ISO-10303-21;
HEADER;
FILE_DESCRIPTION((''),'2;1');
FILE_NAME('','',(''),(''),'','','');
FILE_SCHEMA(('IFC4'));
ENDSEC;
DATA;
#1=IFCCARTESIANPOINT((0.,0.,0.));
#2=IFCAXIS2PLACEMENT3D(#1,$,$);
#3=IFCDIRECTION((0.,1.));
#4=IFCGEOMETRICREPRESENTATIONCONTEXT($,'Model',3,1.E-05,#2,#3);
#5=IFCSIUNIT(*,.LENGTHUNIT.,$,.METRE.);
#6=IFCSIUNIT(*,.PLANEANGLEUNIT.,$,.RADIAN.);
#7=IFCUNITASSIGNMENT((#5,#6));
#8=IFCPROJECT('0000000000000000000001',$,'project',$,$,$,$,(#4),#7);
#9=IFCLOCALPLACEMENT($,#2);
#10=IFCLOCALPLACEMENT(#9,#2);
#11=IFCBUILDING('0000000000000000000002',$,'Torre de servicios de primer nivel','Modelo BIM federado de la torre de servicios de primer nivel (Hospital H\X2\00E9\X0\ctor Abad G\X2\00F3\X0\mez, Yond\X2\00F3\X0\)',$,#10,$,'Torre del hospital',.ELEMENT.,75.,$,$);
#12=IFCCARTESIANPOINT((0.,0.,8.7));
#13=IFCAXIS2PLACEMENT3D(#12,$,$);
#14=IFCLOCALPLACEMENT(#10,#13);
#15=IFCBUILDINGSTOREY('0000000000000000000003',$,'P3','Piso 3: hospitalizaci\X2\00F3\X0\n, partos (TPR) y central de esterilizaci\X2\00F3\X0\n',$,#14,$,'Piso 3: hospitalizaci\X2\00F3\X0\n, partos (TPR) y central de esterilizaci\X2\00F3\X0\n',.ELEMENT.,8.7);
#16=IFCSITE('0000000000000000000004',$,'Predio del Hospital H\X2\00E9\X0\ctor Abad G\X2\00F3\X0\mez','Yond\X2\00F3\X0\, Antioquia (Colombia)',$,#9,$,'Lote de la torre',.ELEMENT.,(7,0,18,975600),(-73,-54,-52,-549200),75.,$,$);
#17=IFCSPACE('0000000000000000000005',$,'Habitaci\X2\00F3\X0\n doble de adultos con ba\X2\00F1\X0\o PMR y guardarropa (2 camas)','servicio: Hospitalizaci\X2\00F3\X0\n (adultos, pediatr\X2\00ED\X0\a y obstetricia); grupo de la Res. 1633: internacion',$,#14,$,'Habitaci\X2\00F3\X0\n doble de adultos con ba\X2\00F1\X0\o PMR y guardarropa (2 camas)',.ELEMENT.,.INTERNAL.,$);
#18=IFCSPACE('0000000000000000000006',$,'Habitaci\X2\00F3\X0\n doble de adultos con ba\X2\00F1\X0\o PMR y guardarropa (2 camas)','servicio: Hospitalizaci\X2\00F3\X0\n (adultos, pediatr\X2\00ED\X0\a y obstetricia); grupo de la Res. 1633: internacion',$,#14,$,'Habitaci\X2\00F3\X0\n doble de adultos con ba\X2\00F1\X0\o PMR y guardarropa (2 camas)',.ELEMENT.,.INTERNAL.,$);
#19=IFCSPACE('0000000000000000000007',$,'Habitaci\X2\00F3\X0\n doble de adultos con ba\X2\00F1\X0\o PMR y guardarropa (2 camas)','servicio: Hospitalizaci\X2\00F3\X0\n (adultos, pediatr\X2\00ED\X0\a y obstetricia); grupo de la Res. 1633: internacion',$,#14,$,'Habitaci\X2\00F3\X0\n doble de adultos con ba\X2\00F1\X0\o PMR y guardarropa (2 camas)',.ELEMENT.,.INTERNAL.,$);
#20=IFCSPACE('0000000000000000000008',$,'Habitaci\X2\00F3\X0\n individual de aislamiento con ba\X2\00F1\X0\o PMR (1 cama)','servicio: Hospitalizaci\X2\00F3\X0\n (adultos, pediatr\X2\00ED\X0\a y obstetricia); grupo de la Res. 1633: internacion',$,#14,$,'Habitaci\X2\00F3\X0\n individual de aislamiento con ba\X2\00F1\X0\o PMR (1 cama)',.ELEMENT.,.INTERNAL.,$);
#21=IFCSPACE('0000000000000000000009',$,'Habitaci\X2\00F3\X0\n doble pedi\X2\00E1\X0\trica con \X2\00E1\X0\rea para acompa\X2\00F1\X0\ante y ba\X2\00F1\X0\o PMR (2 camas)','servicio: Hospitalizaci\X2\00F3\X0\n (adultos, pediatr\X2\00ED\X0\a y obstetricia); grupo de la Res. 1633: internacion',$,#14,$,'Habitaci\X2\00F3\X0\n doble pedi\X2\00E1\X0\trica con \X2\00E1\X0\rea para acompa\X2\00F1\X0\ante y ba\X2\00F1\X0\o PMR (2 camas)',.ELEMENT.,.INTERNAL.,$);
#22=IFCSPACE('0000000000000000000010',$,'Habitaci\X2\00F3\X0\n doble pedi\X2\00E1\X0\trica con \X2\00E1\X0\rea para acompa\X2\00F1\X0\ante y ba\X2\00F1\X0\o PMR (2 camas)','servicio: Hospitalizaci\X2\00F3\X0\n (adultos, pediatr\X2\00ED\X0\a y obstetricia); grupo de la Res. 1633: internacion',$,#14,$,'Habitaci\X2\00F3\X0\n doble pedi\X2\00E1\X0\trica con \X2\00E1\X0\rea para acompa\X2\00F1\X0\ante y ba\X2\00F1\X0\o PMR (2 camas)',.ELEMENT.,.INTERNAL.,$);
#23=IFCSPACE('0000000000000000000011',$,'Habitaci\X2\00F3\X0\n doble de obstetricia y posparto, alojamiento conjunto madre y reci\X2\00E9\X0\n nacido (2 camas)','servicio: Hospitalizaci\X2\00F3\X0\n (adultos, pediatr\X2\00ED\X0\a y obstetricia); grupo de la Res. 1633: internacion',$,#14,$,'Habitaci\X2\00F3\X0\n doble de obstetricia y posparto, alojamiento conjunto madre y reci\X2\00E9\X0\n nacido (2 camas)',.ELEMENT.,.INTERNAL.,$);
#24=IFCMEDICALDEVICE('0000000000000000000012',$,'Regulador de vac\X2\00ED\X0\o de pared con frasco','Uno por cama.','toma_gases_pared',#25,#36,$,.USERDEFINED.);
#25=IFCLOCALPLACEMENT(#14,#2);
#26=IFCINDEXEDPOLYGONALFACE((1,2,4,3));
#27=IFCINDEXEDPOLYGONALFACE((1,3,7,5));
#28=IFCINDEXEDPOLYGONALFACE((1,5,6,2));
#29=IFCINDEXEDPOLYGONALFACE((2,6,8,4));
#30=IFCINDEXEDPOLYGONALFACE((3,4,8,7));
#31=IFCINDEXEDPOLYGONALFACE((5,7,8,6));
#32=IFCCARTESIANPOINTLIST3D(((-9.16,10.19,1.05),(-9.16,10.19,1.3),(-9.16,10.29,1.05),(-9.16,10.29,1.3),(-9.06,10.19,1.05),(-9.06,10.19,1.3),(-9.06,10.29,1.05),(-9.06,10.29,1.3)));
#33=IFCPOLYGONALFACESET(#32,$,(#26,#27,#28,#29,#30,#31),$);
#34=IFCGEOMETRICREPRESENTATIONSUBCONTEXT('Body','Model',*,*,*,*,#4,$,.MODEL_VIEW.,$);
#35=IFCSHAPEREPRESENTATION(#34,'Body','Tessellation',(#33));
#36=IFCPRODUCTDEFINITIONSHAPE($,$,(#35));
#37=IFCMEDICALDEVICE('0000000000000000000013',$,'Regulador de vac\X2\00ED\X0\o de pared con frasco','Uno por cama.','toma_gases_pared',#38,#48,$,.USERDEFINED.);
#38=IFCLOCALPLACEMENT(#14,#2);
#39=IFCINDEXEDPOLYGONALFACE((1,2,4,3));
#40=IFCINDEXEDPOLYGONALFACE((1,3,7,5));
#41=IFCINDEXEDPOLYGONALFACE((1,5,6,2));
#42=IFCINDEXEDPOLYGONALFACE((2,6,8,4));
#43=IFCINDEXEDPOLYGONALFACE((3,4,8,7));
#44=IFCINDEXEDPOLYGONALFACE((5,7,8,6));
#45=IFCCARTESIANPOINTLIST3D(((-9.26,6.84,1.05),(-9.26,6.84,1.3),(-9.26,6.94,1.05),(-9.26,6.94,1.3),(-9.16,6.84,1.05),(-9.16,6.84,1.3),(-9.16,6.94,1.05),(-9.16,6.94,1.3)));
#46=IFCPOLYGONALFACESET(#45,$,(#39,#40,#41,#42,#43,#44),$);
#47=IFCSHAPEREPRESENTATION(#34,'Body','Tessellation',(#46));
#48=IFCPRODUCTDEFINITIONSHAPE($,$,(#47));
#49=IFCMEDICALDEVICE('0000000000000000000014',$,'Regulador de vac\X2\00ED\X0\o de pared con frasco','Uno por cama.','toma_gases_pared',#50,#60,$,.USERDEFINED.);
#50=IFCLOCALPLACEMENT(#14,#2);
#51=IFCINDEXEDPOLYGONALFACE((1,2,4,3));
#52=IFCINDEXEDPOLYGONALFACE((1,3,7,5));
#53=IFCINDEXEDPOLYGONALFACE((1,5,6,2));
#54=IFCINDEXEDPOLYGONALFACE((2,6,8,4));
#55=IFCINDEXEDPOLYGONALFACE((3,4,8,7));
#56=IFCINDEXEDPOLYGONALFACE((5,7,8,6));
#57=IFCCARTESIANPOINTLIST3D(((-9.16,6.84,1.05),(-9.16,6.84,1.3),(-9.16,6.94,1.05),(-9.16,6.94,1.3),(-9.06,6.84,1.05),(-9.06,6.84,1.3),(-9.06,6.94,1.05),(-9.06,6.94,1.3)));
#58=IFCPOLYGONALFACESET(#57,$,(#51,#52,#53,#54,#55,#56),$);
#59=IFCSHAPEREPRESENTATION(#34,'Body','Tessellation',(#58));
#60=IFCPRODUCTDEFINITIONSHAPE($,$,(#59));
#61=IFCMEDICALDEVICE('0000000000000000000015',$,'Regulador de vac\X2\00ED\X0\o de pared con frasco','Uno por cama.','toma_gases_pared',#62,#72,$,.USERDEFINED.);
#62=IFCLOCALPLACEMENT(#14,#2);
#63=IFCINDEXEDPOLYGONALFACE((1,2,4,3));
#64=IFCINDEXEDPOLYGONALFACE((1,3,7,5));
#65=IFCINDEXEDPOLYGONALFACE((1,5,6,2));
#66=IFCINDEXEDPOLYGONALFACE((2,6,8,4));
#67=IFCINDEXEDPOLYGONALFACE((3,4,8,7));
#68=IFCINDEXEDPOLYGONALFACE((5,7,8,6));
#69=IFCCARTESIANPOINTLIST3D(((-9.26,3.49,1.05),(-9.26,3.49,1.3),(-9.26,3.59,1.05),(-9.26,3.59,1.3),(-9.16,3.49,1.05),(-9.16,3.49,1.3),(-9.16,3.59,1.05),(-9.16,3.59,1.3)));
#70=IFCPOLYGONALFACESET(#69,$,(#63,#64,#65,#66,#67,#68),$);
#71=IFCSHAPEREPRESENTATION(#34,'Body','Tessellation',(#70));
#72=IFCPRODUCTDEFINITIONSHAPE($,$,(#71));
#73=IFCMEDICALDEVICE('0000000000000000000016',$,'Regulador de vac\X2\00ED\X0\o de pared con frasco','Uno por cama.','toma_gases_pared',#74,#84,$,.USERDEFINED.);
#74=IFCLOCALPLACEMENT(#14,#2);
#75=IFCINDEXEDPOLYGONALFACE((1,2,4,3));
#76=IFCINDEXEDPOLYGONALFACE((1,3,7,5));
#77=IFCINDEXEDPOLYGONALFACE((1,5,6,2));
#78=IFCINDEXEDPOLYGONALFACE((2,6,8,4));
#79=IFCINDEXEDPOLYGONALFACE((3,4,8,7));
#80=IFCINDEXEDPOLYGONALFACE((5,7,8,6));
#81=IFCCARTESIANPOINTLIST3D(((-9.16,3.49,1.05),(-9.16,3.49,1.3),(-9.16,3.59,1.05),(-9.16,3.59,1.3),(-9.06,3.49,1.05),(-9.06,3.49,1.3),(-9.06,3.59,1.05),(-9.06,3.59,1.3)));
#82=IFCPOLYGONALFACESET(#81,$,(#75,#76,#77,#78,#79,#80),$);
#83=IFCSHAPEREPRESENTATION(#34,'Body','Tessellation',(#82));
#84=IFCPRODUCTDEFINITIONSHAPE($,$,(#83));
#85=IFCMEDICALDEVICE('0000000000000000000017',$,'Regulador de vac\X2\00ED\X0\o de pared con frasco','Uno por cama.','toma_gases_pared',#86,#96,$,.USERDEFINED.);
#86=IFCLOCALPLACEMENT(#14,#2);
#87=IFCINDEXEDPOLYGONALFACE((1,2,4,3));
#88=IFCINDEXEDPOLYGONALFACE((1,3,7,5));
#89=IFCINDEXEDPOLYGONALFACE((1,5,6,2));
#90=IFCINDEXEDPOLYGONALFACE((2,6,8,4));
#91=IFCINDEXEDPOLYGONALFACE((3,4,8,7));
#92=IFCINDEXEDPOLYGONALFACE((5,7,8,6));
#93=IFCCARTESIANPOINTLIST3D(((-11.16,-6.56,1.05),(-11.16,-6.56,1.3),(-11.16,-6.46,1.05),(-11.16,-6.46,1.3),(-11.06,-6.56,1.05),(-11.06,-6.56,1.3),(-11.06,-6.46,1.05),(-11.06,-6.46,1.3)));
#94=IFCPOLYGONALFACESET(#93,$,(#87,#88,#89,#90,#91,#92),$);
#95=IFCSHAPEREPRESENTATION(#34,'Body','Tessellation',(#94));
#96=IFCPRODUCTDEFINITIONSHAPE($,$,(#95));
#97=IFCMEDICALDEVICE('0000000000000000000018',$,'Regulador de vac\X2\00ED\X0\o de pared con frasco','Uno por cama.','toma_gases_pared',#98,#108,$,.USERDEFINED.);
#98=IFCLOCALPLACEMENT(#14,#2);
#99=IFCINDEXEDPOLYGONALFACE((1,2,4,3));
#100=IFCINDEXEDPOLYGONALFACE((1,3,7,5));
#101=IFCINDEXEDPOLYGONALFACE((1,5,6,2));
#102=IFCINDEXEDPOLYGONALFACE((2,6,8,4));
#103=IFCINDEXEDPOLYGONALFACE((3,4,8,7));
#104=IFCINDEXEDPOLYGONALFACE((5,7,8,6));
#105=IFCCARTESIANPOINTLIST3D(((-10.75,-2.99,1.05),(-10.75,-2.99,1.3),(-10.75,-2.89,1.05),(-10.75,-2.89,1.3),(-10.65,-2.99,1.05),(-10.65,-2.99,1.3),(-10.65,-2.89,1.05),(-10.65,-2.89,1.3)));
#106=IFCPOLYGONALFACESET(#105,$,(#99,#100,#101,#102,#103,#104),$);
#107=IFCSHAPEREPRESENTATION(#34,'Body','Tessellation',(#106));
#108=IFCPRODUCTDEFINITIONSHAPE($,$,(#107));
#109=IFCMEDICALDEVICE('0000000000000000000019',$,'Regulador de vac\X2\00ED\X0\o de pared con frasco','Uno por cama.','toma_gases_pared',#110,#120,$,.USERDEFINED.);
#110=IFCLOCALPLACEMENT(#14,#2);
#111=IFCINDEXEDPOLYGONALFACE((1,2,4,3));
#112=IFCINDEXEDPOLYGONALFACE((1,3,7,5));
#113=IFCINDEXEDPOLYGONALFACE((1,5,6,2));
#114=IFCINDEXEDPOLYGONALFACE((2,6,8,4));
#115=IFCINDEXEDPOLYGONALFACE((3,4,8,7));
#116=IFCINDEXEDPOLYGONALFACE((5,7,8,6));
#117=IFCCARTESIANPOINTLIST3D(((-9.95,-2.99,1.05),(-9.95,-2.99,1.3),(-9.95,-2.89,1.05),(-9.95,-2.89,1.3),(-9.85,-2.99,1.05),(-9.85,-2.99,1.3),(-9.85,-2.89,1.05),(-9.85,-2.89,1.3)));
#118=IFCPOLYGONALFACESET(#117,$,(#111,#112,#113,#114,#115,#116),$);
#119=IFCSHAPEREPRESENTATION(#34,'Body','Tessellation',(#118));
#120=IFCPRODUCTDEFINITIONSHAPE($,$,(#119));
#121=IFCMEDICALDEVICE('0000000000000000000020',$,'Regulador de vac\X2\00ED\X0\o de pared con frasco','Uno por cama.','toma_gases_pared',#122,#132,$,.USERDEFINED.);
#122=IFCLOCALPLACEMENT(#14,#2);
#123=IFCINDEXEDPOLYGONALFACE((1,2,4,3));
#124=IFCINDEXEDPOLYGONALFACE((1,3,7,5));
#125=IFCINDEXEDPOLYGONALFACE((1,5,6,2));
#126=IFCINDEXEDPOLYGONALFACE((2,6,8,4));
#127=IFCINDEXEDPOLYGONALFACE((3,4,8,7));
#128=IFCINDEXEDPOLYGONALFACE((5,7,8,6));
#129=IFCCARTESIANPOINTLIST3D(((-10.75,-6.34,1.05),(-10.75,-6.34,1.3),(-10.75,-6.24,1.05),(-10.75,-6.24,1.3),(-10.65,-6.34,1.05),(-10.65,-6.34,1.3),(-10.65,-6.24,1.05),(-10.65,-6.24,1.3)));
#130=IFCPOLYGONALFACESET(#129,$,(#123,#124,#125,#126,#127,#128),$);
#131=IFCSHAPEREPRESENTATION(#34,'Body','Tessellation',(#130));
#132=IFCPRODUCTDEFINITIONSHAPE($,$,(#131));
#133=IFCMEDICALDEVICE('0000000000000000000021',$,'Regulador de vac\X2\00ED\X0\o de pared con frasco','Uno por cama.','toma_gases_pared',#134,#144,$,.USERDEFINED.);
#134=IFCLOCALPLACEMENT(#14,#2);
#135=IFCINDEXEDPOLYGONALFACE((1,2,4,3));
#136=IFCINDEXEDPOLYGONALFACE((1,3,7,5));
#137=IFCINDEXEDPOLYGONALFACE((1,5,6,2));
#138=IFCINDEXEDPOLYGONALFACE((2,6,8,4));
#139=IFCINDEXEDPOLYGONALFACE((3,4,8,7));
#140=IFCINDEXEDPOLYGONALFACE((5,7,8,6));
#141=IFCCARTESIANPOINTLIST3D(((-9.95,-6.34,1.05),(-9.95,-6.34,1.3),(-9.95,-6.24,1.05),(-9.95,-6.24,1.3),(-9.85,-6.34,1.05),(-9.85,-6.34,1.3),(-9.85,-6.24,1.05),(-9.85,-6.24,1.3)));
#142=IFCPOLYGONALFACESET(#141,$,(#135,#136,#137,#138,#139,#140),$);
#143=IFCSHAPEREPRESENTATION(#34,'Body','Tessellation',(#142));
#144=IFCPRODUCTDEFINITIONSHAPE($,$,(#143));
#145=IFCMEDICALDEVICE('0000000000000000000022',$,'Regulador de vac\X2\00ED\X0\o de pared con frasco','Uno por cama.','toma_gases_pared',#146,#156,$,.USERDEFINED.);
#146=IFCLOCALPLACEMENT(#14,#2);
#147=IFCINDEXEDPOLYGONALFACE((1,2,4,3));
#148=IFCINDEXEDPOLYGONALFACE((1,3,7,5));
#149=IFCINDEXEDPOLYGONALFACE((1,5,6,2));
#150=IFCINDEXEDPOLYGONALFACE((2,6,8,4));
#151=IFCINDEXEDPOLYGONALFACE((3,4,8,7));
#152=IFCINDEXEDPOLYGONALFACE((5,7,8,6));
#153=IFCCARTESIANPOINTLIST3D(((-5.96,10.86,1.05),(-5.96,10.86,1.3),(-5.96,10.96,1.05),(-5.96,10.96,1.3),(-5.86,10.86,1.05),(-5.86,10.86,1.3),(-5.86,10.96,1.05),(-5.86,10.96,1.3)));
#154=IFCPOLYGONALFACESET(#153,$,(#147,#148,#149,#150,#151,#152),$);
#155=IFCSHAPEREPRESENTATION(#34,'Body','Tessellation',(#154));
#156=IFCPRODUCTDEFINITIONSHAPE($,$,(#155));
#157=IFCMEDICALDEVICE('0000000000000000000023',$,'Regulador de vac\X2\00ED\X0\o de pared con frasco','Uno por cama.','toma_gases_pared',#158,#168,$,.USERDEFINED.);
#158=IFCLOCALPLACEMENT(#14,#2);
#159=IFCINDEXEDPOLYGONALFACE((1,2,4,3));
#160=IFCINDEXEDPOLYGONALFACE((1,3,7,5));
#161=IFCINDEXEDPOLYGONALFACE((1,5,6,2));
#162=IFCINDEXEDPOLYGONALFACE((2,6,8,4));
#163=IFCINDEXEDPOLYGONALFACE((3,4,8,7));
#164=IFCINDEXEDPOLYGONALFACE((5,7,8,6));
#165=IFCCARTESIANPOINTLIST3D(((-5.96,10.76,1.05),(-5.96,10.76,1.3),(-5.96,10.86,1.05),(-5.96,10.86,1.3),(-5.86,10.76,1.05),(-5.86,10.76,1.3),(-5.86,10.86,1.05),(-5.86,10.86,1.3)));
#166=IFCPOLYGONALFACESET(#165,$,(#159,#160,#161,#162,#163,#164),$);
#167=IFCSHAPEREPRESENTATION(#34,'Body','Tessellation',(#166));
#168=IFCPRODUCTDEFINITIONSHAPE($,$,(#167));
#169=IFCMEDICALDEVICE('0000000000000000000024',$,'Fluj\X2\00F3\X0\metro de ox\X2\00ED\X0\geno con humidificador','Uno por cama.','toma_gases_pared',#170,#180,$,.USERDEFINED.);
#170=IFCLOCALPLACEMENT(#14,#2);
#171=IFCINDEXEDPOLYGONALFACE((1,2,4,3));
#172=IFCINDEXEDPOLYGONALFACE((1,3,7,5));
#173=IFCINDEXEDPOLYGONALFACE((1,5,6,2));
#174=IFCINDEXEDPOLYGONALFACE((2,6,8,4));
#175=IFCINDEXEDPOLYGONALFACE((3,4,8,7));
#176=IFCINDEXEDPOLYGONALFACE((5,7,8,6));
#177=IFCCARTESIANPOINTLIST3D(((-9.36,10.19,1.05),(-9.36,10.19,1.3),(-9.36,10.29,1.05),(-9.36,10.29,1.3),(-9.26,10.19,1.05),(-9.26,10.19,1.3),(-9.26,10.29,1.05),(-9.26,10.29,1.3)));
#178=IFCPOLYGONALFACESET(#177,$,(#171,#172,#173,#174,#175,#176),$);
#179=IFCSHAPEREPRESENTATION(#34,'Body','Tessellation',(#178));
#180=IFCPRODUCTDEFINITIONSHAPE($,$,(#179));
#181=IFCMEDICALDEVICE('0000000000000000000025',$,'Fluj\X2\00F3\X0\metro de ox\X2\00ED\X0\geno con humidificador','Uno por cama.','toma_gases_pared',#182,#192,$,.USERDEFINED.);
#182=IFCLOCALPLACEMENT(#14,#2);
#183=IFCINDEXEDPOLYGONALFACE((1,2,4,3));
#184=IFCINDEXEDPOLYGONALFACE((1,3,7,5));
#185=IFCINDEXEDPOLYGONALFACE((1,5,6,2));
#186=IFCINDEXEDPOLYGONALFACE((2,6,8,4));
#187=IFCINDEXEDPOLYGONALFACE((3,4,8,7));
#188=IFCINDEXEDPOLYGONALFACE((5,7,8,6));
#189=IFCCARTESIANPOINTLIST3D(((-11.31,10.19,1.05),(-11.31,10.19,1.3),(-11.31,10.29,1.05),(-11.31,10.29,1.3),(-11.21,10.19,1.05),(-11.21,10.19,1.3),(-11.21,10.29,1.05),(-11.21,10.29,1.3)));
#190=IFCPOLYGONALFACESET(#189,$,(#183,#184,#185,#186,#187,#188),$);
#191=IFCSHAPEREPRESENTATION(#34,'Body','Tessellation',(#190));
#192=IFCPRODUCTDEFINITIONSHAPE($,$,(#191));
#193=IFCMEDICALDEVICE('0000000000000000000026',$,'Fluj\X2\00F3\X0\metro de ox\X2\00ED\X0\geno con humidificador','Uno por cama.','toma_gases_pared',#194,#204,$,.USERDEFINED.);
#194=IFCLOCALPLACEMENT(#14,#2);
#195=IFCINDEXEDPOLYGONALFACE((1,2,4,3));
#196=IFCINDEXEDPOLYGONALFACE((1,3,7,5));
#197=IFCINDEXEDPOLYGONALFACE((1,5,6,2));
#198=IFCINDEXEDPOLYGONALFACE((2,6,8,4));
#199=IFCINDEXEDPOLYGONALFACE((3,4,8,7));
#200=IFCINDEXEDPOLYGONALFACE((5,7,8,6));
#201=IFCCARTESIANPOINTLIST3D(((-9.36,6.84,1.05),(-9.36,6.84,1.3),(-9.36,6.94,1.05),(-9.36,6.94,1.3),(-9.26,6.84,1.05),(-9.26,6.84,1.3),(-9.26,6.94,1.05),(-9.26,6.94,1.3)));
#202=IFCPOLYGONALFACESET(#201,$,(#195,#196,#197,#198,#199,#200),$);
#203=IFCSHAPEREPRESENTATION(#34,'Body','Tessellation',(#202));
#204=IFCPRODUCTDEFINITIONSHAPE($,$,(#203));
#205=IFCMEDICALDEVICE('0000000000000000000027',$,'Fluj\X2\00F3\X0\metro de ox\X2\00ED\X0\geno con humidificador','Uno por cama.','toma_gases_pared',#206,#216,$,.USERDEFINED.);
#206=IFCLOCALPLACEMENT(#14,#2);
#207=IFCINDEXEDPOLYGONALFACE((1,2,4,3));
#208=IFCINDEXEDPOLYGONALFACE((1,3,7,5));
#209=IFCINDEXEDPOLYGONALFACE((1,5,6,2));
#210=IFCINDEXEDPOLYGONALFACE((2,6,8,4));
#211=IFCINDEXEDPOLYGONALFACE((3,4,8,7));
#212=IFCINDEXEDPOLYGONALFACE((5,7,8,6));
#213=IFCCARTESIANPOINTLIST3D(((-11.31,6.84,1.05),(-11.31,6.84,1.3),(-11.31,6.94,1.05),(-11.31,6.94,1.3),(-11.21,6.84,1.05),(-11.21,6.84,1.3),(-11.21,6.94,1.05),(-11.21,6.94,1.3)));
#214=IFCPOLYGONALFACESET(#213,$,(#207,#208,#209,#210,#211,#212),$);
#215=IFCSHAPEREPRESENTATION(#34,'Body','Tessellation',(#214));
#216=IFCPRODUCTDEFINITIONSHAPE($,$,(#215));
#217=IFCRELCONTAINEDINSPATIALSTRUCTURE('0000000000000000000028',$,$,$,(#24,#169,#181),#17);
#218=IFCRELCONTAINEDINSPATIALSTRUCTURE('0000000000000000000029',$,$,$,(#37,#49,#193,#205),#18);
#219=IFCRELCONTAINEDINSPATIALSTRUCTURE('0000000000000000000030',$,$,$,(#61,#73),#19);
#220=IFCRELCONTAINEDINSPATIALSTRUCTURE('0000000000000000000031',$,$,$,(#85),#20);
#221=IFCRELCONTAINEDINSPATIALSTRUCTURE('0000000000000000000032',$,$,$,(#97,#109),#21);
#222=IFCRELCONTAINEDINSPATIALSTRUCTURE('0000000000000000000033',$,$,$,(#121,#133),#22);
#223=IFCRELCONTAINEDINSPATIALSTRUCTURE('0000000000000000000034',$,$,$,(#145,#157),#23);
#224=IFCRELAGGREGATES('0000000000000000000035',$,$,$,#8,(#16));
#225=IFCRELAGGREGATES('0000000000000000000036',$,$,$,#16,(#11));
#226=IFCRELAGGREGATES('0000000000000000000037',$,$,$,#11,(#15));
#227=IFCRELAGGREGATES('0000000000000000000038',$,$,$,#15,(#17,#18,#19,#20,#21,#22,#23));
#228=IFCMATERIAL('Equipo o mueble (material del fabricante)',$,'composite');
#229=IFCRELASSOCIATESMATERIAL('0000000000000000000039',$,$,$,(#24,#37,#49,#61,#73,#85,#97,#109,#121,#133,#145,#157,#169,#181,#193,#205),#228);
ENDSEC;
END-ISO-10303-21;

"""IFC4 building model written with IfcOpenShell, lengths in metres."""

from ifc_helpers import new_model, si_unit, direction, frame, origin, place, context, subcontext, project, spatial, rectangle, extrude, material, element, save


model = new_model("IFC4")

# Units and contexts
model_context = context("Model", 3, precision=1e-05, world=origin(), true_north=direction((0.0, 1.0)))
body_context = subcontext(model_context, "Body", "Model", "MODEL_VIEW")
ifc_project = project(units=[si_unit("LENGTHUNIT", "METRE"), si_unit("PLANEANGLEUNIT", "RADIAN")], contexts=[model_context])

# Site, building, storey, space
site_placement = place(None, origin())
site = spatial("IfcSite", under=ifc_project, at=site_placement, Name="Predio del Hospital Héctor Abad Gómez", Description="Yondó, Antioquia (Colombia)", LongName="Lote de la torre", CompositionType="ELEMENT", RefLatitude=(7, 0, 18, 975600), RefLongitude=(-73, -54, -52, -549200), RefElevation=75.0)
building_placement = place(site_placement, origin())
building = spatial("IfcBuilding", under=site, at=building_placement, Name="Torre de servicios de primer nivel", Description="Modelo BIM federado de la torre de servicios de primer nivel (Hospital Héctor Abad Gómez, Yondó)", LongName="Torre del hospital", CompositionType="ELEMENT", ElevationOfRefHeight=75.0)
placement = place(building_placement, frame((0.0, 0.0, 8.7)))
storey = spatial("IfcBuildingStorey", under=building, at=placement, Name="P3", Description="Piso 3: hospitalización, partos (TPR) y central de esterilización", LongName="Piso 3: hospitalización, partos (TPR) y central de esterilización", CompositionType="ELEMENT", Elevation=8.7)
space_1 = spatial("IfcSpace", under=storey, at=placement, Name="Habitación doble de adultos con baño PMR y guardarropa (2 camas)", Description="servicio: Hospitalización (adultos, pediatría y obstetricia); grupo de la Res. 1633: internacion", LongName="Habitación doble de adultos con baño PMR y guardarropa (2 camas)", CompositionType="ELEMENT", PredefinedType="INTERNAL")

# Medical device
ifc_material = material(Name="Equipo o mueble (material del fabricante)", Category="composite")
element("IfcMedicalDevice", 1, at=placement, inside=space_1, material=ifc_material, Name="Regulador de vacío de pared con frasco", Description="Uno por cama.", ObjectType="toma_gases_pared", PredefinedType="USERDEFINED", context=body_context, shape_type="SweptSolid", body=[
    extrude(rectangle(XDim=0.1, YDim=0.1), frame((-9.11, 10.24, 1.05), z_axis=(0.0, 0.0, 1.0), x_axis=(-1.0, 0.0, 0.0)), (0.0, 0.0, 1.0), 0.25),
])

# Shared definitions
space_2 = spatial("IfcSpace", under=storey, at=placement, Name="Habitación doble de adultos con baño PMR y guardarropa (2 camas)", Description="servicio: Hospitalización (adultos, pediatría y obstetricia); grupo de la Res. 1633: internacion", LongName="Habitación doble de adultos con baño PMR y guardarropa (2 camas)", CompositionType="ELEMENT", PredefinedType="INTERNAL")

# Medical devices
element("IfcMedicalDevice", 2, at=placement, inside=space_2, material=ifc_material, Name="Regulador de vacío de pared con frasco", Description="Uno por cama.", ObjectType="toma_gases_pared", PredefinedType="USERDEFINED", context=body_context, shape_type="SweptSolid", body=[
    extrude(rectangle(XDim=0.1, YDim=0.1), frame((-9.21, 6.89, 1.05), z_axis=(0.0, 0.0, 1.0), x_axis=(-1.0, 0.0, 0.0)), (0.0, 0.0, 1.0), 0.25),
])
element("IfcMedicalDevice", 3, at=placement, inside=space_2, material=ifc_material, Name="Regulador de vacío de pared con frasco", Description="Uno por cama.", ObjectType="toma_gases_pared", PredefinedType="USERDEFINED", context=body_context, shape_type="SweptSolid", body=[
    extrude(rectangle(XDim=0.1, YDim=0.1), frame((-9.11, 6.89, 1.05), z_axis=(0.0, 0.0, 1.0), x_axis=(-1.0, 0.0, 0.0)), (0.0, 0.0, 1.0), 0.25),
])

# Shared definitions
space_3 = spatial("IfcSpace", under=storey, at=placement, Name="Habitación doble de adultos con baño PMR y guardarropa (2 camas)", Description="servicio: Hospitalización (adultos, pediatría y obstetricia); grupo de la Res. 1633: internacion", LongName="Habitación doble de adultos con baño PMR y guardarropa (2 camas)", CompositionType="ELEMENT", PredefinedType="INTERNAL")

# Medical devices
element("IfcMedicalDevice", 4, at=placement, inside=space_3, material=ifc_material, Name="Regulador de vacío de pared con frasco", Description="Uno por cama.", ObjectType="toma_gases_pared", PredefinedType="USERDEFINED", context=body_context, shape_type="SweptSolid", body=[
    extrude(rectangle(XDim=0.1, YDim=0.1), frame((-9.21, 3.54, 1.05), z_axis=(0.0, 0.0, 1.0), x_axis=(-1.0, 0.0, 0.0)), (0.0, 0.0, 1.0), 0.25),
])
element("IfcMedicalDevice", 5, at=placement, inside=space_3, material=ifc_material, Name="Regulador de vacío de pared con frasco", Description="Uno por cama.", ObjectType="toma_gases_pared", PredefinedType="USERDEFINED", context=body_context, shape_type="SweptSolid", body=[
    extrude(rectangle(XDim=0.1, YDim=0.1), frame((-9.11, 3.54, 1.05), z_axis=(0.0, 0.0, 1.0), x_axis=(-1.0, 0.0, 0.0)), (0.0, 0.0, 1.0), 0.25),
])

# Shared definitions
space_4 = spatial("IfcSpace", under=storey, at=placement, Name="Habitación individual de aislamiento con baño PMR (1 cama)", Description="servicio: Hospitalización (adultos, pediatría y obstetricia); grupo de la Res. 1633: internacion", LongName="Habitación individual de aislamiento con baño PMR (1 cama)", CompositionType="ELEMENT", PredefinedType="INTERNAL")

# Medical device
element("IfcMedicalDevice", 6, at=placement, inside=space_4, material=ifc_material, Name="Regulador de vacío de pared con frasco", Description="Uno por cama.", ObjectType="toma_gases_pared", PredefinedType="USERDEFINED", context=body_context, shape_type="SweptSolid", body=[
    extrude(rectangle(XDim=0.1, YDim=0.1), frame((-11.11, -6.51, 1.05), z_axis=(0.0, 0.0, 1.0), x_axis=(-1.0, 0.0, 0.0)), (0.0, 0.0, 1.0), 0.25),
])

# Shared definitions
space_5 = spatial("IfcSpace", under=storey, at=placement, Name="Habitación doble pediátrica con área para acompañante y baño PMR (2 camas)", Description="servicio: Hospitalización (adultos, pediatría y obstetricia); grupo de la Res. 1633: internacion", LongName="Habitación doble pediátrica con área para acompañante y baño PMR (2 camas)", CompositionType="ELEMENT", PredefinedType="INTERNAL")

# Medical devices
element("IfcMedicalDevice", 7, at=placement, inside=space_5, material=ifc_material, Name="Regulador de vacío de pared con frasco", Description="Uno por cama.", ObjectType="toma_gases_pared", PredefinedType="USERDEFINED", context=body_context, shape_type="SweptSolid", body=[
    extrude(rectangle(XDim=0.1, YDim=0.1), frame((-10.7, -2.94, 1.05)), (0.0, 0.0, 1.0), 0.25),
])
element("IfcMedicalDevice", 8, at=placement, inside=space_5, material=ifc_material, Name="Regulador de vacío de pared con frasco", Description="Uno por cama.", ObjectType="toma_gases_pared", PredefinedType="USERDEFINED", context=body_context, shape_type="SweptSolid", body=[
    extrude(rectangle(XDim=0.1, YDim=0.1), frame((-9.9, -2.94, 1.05)), (0.0, 0.0, 1.0), 0.25),
])

# Shared definitions
space_6 = spatial("IfcSpace", under=storey, at=placement, Name="Habitación doble pediátrica con área para acompañante y baño PMR (2 camas)", Description="servicio: Hospitalización (adultos, pediatría y obstetricia); grupo de la Res. 1633: internacion", LongName="Habitación doble pediátrica con área para acompañante y baño PMR (2 camas)", CompositionType="ELEMENT", PredefinedType="INTERNAL")

# Medical devices
element("IfcMedicalDevice", 9, at=placement, inside=space_6, material=ifc_material, Name="Regulador de vacío de pared con frasco", Description="Uno por cama.", ObjectType="toma_gases_pared", PredefinedType="USERDEFINED", context=body_context, shape_type="SweptSolid", body=[
    extrude(rectangle(XDim=0.1, YDim=0.1), frame((-10.7, -6.29, 1.05)), (0.0, 0.0, 1.0), 0.25),
])
element("IfcMedicalDevice", 10, at=placement, inside=space_6, material=ifc_material, Name="Regulador de vacío de pared con frasco", Description="Uno por cama.", ObjectType="toma_gases_pared", PredefinedType="USERDEFINED", context=body_context, shape_type="SweptSolid", body=[
    extrude(rectangle(XDim=0.1, YDim=0.1), frame((-9.9, -6.29, 1.05)), (0.0, 0.0, 1.0), 0.25),
])

# Shared definitions
space_7 = spatial("IfcSpace", under=storey, at=placement, Name="Habitación doble de obstetricia y posparto, alojamiento conjunto madre y recién nacido (2 camas)", Description="servicio: Hospitalización (adultos, pediatría y obstetricia); grupo de la Res. 1633: internacion", LongName="Habitación doble de obstetricia y posparto, alojamiento conjunto madre y recién nacido (2 camas)", CompositionType="ELEMENT", PredefinedType="INTERNAL")

# Medical devices
element("IfcMedicalDevice", 11, at=placement, inside=space_7, material=ifc_material, Name="Regulador de vacío de pared con frasco", Description="Uno por cama.", ObjectType="toma_gases_pared", PredefinedType="USERDEFINED", context=body_context, shape_type="SweptSolid", body=[
    extrude(rectangle(XDim=0.1, YDim=0.1), frame((-5.91, 10.91, 1.05), z_axis=(0.0, 0.0, 1.0), x_axis=(0.0, 1.0, 0.0)), (0.0, 0.0, 1.0), 0.25),
])
element("IfcMedicalDevice", 12, at=placement, inside=space_7, material=ifc_material, Name="Regulador de vacío de pared con frasco", Description="Uno por cama.", ObjectType="toma_gases_pared", PredefinedType="USERDEFINED", context=body_context, shape_type="SweptSolid", body=[
    extrude(rectangle(XDim=0.1, YDim=0.1), frame((-5.91, 10.81, 1.05), z_axis=(0.0, 0.0, 1.0), x_axis=(0.0, 1.0, 0.0)), (0.0, 0.0, 1.0), 0.25),
])
element("IfcMedicalDevice", 13, at=placement, inside=space_1, material=ifc_material, Name="Flujómetro de oxígeno con humidificador", Description="Uno por cama.", ObjectType="toma_gases_pared", PredefinedType="USERDEFINED", context=body_context, shape_type="SweptSolid", body=[
    extrude(rectangle(XDim=0.1, YDim=0.1), frame((-9.31, 10.24, 1.05), z_axis=(0.0, 0.0, 1.0), x_axis=(-1.0, 0.0, 0.0)), (0.0, 0.0, 1.0), 0.25),
])
element("IfcMedicalDevice", 14, at=placement, inside=space_1, material=ifc_material, Name="Flujómetro de oxígeno con humidificador", Description="Uno por cama.", ObjectType="toma_gases_pared", PredefinedType="USERDEFINED", context=body_context, shape_type="SweptSolid", body=[
    extrude(rectangle(XDim=0.1, YDim=0.1), frame((-11.26, 10.24, 1.05), z_axis=(0.0, 0.0, 1.0), x_axis=(-1.0, 0.0, 0.0)), (0.0, 0.0, 1.0), 0.25),
])
element("IfcMedicalDevice", 15, at=placement, inside=space_2, material=ifc_material, Name="Flujómetro de oxígeno con humidificador", Description="Uno por cama.", ObjectType="toma_gases_pared", PredefinedType="USERDEFINED", context=body_context, shape_type="SweptSolid", body=[
    extrude(rectangle(XDim=0.1, YDim=0.1), frame((-9.31, 6.89, 1.05), z_axis=(0.0, 0.0, 1.0), x_axis=(-1.0, 0.0, 0.0)), (0.0, 0.0, 1.0), 0.25),
])
element("IfcMedicalDevice", 16, at=placement, inside=space_2, material=ifc_material, Name="Flujómetro de oxígeno con humidificador", Description="Uno por cama.", ObjectType="toma_gases_pared", PredefinedType="USERDEFINED", context=body_context, shape_type="SweptSolid", body=[
    extrude(rectangle(XDim=0.1, YDim=0.1), frame((-11.26, 6.89, 1.05), z_axis=(0.0, 0.0, 1.0), x_axis=(-1.0, 0.0, 0.0)), (0.0, 0.0, 1.0), 0.25),
])

save(model, "model.ifc")
